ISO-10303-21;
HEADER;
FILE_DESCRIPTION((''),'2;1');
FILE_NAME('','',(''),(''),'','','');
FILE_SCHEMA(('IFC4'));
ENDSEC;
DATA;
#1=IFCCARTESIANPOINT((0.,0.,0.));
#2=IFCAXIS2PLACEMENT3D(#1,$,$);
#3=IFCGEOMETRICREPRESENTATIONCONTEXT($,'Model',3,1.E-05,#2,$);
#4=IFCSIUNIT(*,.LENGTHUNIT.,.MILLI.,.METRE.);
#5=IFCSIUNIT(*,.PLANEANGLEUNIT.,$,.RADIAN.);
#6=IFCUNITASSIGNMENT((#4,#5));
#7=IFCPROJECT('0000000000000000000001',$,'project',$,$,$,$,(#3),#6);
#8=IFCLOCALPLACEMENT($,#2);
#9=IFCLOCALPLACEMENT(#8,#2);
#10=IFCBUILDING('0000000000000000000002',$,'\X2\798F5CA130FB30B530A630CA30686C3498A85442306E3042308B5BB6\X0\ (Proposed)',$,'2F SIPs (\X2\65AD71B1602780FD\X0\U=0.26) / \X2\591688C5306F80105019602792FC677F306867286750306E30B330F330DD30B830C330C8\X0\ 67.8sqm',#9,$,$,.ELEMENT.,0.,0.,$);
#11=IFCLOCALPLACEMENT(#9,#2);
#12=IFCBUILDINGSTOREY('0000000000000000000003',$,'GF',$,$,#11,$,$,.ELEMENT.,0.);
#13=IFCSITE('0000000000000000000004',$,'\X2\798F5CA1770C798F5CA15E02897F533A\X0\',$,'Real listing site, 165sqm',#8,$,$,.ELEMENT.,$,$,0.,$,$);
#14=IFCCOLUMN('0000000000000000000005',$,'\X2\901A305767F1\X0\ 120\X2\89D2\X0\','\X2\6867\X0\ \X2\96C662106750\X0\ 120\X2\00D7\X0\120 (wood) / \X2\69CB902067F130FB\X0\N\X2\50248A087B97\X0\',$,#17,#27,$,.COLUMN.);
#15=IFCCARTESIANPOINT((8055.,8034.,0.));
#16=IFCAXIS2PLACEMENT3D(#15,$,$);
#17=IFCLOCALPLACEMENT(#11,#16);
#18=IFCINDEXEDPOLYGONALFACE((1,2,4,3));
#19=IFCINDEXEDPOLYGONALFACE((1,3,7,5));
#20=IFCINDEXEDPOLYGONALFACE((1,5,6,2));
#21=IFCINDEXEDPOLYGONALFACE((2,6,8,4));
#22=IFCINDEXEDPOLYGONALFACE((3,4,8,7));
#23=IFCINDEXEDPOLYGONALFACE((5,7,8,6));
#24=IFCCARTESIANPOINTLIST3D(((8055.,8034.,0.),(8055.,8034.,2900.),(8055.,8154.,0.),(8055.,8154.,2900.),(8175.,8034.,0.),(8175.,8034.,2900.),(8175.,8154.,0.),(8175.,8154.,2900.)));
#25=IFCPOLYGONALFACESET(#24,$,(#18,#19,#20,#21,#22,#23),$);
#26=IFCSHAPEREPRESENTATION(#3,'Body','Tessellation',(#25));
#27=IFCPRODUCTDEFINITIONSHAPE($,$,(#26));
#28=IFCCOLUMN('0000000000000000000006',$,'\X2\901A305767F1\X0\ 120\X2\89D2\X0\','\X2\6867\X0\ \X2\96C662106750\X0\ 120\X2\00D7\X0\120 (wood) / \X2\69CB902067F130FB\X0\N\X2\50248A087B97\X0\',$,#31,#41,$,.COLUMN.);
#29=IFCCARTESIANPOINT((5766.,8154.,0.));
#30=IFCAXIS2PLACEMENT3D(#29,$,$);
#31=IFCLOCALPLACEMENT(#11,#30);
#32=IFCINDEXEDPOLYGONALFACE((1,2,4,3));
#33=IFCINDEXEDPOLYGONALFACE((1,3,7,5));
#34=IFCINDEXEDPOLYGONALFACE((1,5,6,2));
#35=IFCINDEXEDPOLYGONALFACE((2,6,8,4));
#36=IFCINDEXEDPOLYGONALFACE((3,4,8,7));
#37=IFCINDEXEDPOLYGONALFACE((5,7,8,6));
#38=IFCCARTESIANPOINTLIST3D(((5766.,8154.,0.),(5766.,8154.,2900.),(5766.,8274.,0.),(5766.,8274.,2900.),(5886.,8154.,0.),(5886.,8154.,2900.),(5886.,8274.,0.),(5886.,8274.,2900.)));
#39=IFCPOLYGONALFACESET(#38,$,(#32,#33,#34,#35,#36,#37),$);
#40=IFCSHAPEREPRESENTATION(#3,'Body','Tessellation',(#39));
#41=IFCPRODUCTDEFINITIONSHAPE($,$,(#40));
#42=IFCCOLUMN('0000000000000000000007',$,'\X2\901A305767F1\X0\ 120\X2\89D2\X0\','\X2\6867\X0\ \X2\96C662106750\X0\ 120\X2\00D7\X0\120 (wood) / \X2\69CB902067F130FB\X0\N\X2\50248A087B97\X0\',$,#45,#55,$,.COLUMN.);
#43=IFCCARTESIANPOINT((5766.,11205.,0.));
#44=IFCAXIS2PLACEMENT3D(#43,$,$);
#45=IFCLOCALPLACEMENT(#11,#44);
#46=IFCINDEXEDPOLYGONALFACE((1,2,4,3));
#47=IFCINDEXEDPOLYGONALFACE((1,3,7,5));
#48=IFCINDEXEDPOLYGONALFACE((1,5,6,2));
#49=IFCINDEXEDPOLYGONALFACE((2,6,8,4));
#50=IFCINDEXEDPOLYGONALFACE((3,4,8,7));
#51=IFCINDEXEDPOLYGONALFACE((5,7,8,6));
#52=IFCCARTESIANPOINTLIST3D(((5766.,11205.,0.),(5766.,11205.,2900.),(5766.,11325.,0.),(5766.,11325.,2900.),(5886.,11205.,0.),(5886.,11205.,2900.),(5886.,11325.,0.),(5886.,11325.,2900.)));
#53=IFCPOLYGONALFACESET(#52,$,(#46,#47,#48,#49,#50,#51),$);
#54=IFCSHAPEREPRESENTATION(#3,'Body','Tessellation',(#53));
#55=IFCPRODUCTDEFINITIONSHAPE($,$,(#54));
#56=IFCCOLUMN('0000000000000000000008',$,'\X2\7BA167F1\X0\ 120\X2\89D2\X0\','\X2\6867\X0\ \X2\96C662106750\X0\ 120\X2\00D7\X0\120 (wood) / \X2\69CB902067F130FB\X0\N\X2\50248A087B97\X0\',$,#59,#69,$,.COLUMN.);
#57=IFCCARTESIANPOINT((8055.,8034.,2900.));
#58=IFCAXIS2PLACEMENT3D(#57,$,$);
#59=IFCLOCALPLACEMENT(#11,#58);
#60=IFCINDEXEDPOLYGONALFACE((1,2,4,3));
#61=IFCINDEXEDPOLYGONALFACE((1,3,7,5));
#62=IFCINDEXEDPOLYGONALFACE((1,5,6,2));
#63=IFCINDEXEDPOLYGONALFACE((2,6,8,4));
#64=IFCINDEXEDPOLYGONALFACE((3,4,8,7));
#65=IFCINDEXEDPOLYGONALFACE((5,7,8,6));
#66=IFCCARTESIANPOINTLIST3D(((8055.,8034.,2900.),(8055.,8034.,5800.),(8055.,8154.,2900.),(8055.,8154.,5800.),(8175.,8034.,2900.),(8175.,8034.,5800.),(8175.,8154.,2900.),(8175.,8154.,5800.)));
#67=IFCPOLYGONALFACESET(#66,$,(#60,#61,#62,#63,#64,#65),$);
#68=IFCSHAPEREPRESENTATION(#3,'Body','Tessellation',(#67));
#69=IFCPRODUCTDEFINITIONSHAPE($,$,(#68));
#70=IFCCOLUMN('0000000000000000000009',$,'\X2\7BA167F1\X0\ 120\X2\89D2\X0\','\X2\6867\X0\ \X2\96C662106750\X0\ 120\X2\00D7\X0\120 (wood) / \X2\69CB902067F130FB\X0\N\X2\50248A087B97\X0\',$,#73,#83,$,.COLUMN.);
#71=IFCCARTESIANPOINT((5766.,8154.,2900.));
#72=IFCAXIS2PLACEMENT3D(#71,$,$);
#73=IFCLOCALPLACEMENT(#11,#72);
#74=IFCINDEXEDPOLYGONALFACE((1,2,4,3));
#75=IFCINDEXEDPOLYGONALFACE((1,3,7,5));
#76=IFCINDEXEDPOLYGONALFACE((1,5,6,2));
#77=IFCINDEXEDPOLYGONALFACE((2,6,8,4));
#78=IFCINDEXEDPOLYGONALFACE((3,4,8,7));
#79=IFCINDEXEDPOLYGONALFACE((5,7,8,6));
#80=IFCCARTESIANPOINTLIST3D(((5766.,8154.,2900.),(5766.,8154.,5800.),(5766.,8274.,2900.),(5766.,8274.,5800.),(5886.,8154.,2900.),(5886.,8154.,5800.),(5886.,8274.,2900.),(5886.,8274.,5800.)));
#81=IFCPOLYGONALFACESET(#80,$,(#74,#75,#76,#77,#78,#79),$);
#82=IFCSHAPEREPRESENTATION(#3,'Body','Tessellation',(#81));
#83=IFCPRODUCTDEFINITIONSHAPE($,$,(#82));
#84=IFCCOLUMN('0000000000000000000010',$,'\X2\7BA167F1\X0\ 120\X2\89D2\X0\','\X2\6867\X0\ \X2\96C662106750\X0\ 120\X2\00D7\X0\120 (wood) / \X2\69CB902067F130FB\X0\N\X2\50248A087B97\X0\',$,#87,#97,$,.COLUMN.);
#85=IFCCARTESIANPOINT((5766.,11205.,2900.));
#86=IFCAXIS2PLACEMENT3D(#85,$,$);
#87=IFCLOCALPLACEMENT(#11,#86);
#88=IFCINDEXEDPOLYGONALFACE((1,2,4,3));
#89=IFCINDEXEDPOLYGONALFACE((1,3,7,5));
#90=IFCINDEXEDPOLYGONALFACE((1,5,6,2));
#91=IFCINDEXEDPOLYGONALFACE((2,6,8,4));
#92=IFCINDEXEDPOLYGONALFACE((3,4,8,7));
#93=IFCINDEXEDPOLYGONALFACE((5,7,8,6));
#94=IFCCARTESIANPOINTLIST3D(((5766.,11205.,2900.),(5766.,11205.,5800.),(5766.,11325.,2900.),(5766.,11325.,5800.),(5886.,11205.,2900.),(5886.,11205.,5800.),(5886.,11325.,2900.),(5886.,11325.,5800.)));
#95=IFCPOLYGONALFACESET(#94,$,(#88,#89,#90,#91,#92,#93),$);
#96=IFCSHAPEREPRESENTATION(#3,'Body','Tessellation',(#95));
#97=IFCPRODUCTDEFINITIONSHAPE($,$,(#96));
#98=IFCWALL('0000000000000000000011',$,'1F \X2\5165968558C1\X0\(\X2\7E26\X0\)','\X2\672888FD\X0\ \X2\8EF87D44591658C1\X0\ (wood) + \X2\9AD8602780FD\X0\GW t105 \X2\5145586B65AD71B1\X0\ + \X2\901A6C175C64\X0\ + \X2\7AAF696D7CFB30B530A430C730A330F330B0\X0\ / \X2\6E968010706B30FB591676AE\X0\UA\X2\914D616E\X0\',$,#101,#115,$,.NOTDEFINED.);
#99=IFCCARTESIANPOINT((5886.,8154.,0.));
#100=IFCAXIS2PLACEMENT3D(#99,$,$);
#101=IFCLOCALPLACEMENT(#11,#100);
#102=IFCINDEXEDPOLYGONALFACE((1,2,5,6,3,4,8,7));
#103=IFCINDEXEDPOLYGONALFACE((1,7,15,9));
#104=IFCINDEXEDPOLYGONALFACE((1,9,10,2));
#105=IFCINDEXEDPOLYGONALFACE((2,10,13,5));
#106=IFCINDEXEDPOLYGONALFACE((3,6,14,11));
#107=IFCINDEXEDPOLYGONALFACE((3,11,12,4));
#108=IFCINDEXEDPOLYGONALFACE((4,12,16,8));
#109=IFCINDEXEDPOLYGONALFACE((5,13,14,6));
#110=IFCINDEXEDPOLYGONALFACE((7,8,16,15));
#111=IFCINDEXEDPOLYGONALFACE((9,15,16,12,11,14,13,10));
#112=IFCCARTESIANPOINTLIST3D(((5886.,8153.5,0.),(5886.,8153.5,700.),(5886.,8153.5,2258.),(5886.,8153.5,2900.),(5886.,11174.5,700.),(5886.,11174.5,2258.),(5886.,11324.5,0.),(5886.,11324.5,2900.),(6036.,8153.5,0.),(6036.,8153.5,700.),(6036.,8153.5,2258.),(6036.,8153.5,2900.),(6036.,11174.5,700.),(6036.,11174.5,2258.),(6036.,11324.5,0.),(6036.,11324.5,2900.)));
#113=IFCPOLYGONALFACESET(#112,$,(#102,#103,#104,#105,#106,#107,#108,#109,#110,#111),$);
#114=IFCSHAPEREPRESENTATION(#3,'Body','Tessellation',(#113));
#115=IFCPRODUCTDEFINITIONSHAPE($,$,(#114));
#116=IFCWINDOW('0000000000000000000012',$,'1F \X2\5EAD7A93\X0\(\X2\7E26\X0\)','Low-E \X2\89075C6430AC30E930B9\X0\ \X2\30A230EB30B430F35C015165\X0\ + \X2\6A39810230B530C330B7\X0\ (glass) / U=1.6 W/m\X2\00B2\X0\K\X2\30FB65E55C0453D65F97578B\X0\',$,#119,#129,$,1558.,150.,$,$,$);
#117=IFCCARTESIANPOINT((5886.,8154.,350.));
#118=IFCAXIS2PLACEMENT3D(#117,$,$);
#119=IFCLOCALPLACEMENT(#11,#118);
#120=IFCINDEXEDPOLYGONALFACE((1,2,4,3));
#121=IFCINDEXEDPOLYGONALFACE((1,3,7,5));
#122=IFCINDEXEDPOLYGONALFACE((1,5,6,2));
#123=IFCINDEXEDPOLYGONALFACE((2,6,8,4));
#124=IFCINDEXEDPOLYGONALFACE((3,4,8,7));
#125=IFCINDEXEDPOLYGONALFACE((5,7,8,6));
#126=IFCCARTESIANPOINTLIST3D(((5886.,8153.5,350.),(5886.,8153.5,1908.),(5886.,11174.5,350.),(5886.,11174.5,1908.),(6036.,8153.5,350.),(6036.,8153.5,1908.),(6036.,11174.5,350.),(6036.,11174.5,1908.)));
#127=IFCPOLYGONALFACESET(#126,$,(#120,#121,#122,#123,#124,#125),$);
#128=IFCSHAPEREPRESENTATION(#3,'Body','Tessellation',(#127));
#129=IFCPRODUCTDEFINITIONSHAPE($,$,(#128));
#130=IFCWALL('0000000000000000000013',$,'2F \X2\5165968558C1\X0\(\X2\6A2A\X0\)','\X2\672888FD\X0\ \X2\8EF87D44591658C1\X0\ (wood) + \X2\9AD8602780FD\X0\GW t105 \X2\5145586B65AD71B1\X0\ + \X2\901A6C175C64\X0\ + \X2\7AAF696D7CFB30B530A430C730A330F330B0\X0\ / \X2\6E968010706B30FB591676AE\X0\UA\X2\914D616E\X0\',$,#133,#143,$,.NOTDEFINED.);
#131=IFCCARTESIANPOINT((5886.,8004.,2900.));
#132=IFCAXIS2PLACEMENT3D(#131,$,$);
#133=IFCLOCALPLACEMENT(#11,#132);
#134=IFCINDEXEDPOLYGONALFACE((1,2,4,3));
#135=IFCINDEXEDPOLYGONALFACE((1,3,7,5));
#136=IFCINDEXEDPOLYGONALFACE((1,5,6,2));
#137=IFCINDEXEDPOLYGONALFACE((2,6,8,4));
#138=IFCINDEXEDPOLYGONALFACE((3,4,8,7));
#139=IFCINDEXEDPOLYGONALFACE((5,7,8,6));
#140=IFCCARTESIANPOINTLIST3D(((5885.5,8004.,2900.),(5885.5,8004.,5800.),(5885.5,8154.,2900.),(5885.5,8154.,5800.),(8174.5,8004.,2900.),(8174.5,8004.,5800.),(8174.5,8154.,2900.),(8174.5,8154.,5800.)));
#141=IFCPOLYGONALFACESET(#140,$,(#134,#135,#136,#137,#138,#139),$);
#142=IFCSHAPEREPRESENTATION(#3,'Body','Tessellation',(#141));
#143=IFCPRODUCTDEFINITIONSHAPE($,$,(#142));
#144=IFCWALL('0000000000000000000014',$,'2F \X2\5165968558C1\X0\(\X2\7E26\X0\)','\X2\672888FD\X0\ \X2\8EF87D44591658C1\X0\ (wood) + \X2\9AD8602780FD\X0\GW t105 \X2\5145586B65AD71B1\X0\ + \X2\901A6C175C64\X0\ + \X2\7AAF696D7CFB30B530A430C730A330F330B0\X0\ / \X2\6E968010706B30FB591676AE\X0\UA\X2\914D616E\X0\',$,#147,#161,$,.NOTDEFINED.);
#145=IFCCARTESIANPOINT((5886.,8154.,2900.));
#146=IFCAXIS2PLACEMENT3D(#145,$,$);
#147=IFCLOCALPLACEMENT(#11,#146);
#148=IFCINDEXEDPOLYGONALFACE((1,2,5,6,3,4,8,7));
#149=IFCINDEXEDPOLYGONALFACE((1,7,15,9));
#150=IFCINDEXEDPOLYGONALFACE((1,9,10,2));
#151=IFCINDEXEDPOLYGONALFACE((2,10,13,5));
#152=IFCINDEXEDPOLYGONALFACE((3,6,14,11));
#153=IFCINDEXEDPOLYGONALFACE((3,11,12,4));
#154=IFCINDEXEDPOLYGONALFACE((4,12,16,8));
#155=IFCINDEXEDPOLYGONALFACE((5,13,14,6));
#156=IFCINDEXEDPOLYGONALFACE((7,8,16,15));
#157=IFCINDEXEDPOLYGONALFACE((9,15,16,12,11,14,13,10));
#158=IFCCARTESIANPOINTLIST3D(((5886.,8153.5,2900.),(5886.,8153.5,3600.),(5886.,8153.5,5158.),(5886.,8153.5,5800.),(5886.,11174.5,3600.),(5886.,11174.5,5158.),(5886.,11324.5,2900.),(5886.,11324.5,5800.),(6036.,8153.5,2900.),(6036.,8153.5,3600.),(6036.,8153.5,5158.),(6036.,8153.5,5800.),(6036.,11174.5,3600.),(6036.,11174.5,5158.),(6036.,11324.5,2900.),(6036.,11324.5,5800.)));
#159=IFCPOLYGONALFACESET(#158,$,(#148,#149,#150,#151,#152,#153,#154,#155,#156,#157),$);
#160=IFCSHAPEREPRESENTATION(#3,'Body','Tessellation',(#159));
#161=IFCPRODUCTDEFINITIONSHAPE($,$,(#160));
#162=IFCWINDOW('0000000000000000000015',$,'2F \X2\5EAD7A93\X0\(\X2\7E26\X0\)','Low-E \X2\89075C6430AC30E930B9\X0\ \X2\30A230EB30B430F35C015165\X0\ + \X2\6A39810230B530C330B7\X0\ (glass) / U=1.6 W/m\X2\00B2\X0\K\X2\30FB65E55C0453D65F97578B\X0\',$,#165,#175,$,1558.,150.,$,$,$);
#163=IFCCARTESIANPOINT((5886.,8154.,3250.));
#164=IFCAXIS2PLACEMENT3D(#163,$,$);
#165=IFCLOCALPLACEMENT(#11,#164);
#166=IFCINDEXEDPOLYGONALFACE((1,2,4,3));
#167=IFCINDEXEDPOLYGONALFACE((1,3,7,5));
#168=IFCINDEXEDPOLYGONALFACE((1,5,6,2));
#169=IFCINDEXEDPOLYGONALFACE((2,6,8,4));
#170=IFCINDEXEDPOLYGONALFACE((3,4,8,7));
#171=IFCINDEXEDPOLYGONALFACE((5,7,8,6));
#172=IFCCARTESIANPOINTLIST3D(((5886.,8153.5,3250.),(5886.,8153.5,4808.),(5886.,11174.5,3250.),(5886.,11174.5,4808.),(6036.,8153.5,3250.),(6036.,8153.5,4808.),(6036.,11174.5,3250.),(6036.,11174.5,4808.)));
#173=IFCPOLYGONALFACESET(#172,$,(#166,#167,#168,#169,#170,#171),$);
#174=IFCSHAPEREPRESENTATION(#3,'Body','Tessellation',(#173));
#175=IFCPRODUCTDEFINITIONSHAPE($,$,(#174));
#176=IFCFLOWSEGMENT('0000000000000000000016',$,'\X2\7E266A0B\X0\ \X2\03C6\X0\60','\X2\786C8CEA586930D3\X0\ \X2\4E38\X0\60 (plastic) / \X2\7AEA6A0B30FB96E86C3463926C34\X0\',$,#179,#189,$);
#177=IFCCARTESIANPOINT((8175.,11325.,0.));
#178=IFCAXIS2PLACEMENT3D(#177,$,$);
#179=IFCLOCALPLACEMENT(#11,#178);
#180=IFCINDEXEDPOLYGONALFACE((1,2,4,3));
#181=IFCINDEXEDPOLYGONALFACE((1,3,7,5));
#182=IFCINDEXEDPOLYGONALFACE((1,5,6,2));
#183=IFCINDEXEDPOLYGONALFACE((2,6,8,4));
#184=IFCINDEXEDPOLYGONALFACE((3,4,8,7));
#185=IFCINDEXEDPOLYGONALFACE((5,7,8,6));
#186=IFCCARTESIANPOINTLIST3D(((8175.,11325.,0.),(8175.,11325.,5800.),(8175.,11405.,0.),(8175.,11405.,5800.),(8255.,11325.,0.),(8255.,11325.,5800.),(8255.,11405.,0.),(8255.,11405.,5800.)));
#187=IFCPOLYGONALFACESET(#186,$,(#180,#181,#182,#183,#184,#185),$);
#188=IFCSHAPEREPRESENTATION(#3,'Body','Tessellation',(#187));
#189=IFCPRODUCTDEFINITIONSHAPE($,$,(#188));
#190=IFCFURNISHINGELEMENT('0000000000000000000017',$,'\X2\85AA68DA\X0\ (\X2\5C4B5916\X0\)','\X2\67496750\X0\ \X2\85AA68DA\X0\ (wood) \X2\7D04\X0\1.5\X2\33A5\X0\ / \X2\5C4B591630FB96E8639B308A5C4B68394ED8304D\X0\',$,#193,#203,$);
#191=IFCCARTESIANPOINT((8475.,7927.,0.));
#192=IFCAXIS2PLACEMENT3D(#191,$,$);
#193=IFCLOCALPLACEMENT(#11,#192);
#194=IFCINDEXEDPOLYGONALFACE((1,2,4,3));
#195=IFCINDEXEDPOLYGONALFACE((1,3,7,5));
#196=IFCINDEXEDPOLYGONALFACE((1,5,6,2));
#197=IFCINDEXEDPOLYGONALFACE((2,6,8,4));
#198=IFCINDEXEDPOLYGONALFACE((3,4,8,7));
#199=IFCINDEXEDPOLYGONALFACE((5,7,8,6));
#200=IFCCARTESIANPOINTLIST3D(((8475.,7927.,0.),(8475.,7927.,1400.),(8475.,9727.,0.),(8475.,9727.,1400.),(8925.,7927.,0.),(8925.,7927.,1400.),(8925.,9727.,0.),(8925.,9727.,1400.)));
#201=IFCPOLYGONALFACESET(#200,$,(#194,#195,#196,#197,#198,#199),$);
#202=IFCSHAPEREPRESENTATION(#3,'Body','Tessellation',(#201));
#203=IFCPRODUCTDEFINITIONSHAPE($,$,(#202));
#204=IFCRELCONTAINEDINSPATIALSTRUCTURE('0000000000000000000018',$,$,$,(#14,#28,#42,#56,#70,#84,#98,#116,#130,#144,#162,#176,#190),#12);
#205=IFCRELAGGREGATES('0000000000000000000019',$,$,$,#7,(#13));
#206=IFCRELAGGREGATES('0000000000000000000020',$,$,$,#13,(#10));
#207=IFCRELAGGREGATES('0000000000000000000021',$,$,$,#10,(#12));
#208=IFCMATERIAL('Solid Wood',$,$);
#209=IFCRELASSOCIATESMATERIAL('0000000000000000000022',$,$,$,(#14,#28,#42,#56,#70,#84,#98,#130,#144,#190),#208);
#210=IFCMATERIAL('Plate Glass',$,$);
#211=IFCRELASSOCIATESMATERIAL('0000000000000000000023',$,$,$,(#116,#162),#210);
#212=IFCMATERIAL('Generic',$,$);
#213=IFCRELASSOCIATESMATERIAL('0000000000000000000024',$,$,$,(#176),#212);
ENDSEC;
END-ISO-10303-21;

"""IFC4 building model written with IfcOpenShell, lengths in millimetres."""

from ifc_helpers import new_model, si_unit, frame, frame_2d, origin, place, context, project, spatial, rectangle, extrude, material, element, fill, save


model = new_model("IFC4")

# Units and contexts
model_context = context("Model", 3, precision=1e-05, world=origin())
ifc_project = project(units=[si_unit("LENGTHUNIT", "METRE", prefix="MILLI"), si_unit("PLANEANGLEUNIT", "RADIAN")], contexts=[model_context])

# Site, building, storey
site_placement = place(None, origin())
site = spatial("IfcSite", under=ifc_project, at=site_placement, Name="福岡県福岡市西区", ObjectType="Real listing site, 165sqm", CompositionType="ELEMENT", RefElevation=0.0)
building_placement = place(site_placement, origin())
building = spatial("IfcBuilding", under=site, at=building_placement, Name="福岡・サウナと水風呂のある家 (Proposed)", ObjectType="2F SIPs (断熱性能U=0.26) / 外装は耐候性鋼板と木材のコンポジット 67.8sqm", CompositionType="ELEMENT", ElevationOfRefHeight=0.0, ElevationOfTerrain=0.0)
storey_placement = place(building_placement, origin())
storey = spatial("IfcBuildingStorey", under=building, at=storey_placement, Name="GF", CompositionType="ELEMENT", Elevation=0.0)

# Columns
ifc_material_1 = material(Name="Solid Wood")
column_1_placement = place(storey_placement, frame((8055.0, 8034.0, 0.0)))
element("IfcColumn", 1, at=column_1_placement, inside=storey, material=ifc_material_1, Name="通し柱 120角", Description="桧 集成材 120×120 (wood) / 構造柱・N値計算", PredefinedType="COLUMN", context=model_context, shape_type="SweptSolid", body=[
    extrude(rectangle(XDim=120.0, YDim=120.0, at=frame_2d((60.0, 60.0))), frame((8055.0, 8034.0, 0.0)), (0.0, 0.0, 1.0), 2900.0),
])
column_2_placement = place(storey_placement, frame((5766.0, 8154.0, 0.0)))
element("IfcColumn", 2, at=column_2_placement, inside=storey, material=ifc_material_1, Name="通し柱 120角", Description="桧 集成材 120×120 (wood) / 構造柱・N値計算", PredefinedType="COLUMN", context=model_context, shape_type="SweptSolid", body=[
    extrude(rectangle(XDim=120.0, YDim=120.0, at=frame_2d((60.0, 60.0))), frame((5766.0, 8154.0, 0.0)), (0.0, 0.0, 1.0), 2900.0),
])
column_3_placement = place(storey_placement, frame((5766.0, 11205.0, 0.0)))
element("IfcColumn", 3, at=column_3_placement, inside=storey, material=ifc_material_1, Name="通し柱 120角", Description="桧 集成材 120×120 (wood) / 構造柱・N値計算", PredefinedType="COLUMN", context=model_context, shape_type="SweptSolid", body=[
    extrude(rectangle(XDim=120.0, YDim=120.0, at=frame_2d((60.0, 60.0))), frame((5766.0, 11205.0, 0.0)), (0.0, 0.0, 1.0), 2900.0),
])
column_4_placement = place(storey_placement, frame((8055.0, 8034.0, 2900.0)))
element("IfcColumn", 4, at=column_4_placement, inside=storey, material=ifc_material_1, Name="管柱 120角", Description="桧 集成材 120×120 (wood) / 構造柱・N値計算", PredefinedType="COLUMN", context=model_context, shape_type="SweptSolid", body=[
    extrude(rectangle(XDim=120.0, YDim=120.0, at=frame_2d((60.0, 60.0))), frame((8055.0, 8034.0, 2900.0)), (0.0, 0.0, 1.0), 2900.0),
])
column_5_placement = place(storey_placement, frame((5766.0, 8154.0, 2900.0)))
element("IfcColumn", 5, at=column_5_placement, inside=storey, material=ifc_material_1, Name="管柱 120角", Description="桧 集成材 120×120 (wood) / 構造柱・N値計算", PredefinedType="COLUMN", context=model_context, shape_type="SweptSolid", body=[
    extrude(rectangle(XDim=120.0, YDim=120.0, at=frame_2d((60.0, 60.0))), frame((5766.0, 8154.0, 2900.0)), (0.0, 0.0, 1.0), 2900.0),
])
column_6_placement = place(storey_placement, frame((5766.0, 11205.0, 2900.0)))
element("IfcColumn", 6, at=column_6_placement, inside=storey, material=ifc_material_1, Name="管柱 120角", Description="桧 集成材 120×120 (wood) / 構造柱・N値計算", PredefinedType="COLUMN", context=model_context, shape_type="SweptSolid", body=[
    extrude(rectangle(XDim=120.0, YDim=120.0, at=frame_2d((60.0, 60.0))), frame((5766.0, 11205.0, 2900.0)), (0.0, 0.0, 1.0), 2900.0),
])

# Wall, opening, window
wall_1_placement = place(storey_placement, frame((5886.0, 8154.0, 0.0)))
wall_1 = element("IfcWall", 7, at=wall_1_placement, inside=storey, material=ifc_material_1, Name="1F 入隅壁(縦)", Description="木製 軸組外壁 (wood) + 高性能GW t105 充填断熱 + 通気層 + 窯業系サイディング / 準耐火・外皮UA配慮", PredefinedType="NOTDEFINED", context=model_context, shape_type="SweptSolid", body=[
    extrude(rectangle(XDim=150.0, YDim=3171.0, at=frame_2d((75.0, 1585.0))), frame((5886.0, 8154.0, 0.0)), (0.0, 0.0, 1.0), 2900.0),
])
opening_1_placement = place(storey_placement, frame((5886.0, 8154.0, 350.0)))
opening_1 = element("IfcOpeningElement", 8, at=opening_1_placement, cuts=wall_1, PredefinedType="NOTDEFINED", context=model_context, shape_type="SweptSolid", body=[
    extrude(rectangle(XDim=150.0, YDim=3021.0, at=frame_2d((75.0, 1510.0))), frame((5886.0, 8154.0, 350.0)), (0.0, 0.0, 1.0), 1558.0),
])
ifc_material_2 = material(Name="Plate Glass")
window_1_placement = place(storey_placement, frame((5886.0, 8154.0, 350.0)))
window_1 = element("IfcWindow", 9, at=window_1_placement, inside=storey, material=ifc_material_2, Name="1F 庭窓(縦)", Description="Low-E 複層ガラス アルゴン封入 + 樹脂サッシ (glass) / U=1.6 W/m²K・日射取得型", OverallHeight=1558.0, OverallWidth=150.0, context=model_context, shape_type="SweptSolid", body=[
    extrude(rectangle(XDim=150.0, YDim=3021.0, at=frame_2d((75.0, 1510.0))), frame((5886.0, 8154.0, 350.0)), (0.0, 0.0, 1.0), 1558.0),
])
fill(opening_1, window_1)

# Wall
wall_2_placement = place(storey_placement, frame((5886.0, 8004.0, 2900.0)))
element("IfcWall", 10, at=wall_2_placement, inside=storey, material=ifc_material_1, Name="2F 入隅壁(横)", Description="木製 軸組外壁 (wood) + 高性能GW t105 充填断熱 + 通気層 + 窯業系サイディング / 準耐火・外皮UA配慮", PredefinedType="NOTDEFINED", context=model_context, shape_type="SweptSolid", body=[
    extrude(rectangle(XDim=2289.0, YDim=150.0, at=frame_2d((1144.0, 75.0))), frame((5886.0, 8004.0, 2900.0)), (0.0, 0.0, 1.0), 2900.0),
])

# Wall, opening, window
wall_3_placement = place(storey_placement, frame((5886.0, 8154.0, 2900.0)))
wall_3 = element("IfcWall", 11, at=wall_3_placement, inside=storey, material=ifc_material_1, Name="2F 入隅壁(縦)", Description="木製 軸組外壁 (wood) + 高性能GW t105 充填断熱 + 通気層 + 窯業系サイディング / 準耐火・外皮UA配慮", PredefinedType="NOTDEFINED", context=model_context, shape_type="SweptSolid", body=[
    extrude(rectangle(XDim=150.0, YDim=3171.0, at=frame_2d((75.0, 1585.0))), frame((5886.0, 8154.0, 2900.0)), (0.0, 0.0, 1.0), 2900.0),
])
opening_2_placement = place(storey_placement, frame((5886.0, 8154.0, 3250.0)))
opening_2 = element("IfcOpeningElement", 12, at=opening_2_placement, cuts=wall_3, PredefinedType="NOTDEFINED", context=model_context, shape_type="SweptSolid", body=[
    extrude(rectangle(XDim=150.0, YDim=3021.0, at=frame_2d((75.0, 1510.0))), frame((5886.0, 8154.0, 3250.0)), (0.0, 0.0, 1.0), 1558.0),
])
window_2_placement = place(storey_placement, frame((5886.0, 8154.0, 3250.0)))
window_2 = element("IfcWindow", 13, at=window_2_placement, inside=storey, material=ifc_material_2, Name="2F 庭窓(縦)", Description="Low-E 複層ガラス アルゴン封入 + 樹脂サッシ (glass) / U=1.6 W/m²K・日射取得型", OverallHeight=1558.0, OverallWidth=150.0, context=model_context, shape_type="SweptSolid", body=[
    extrude(rectangle(XDim=150.0, YDim=3021.0, at=frame_2d((75.0, 1510.0))), frame((5886.0, 8154.0, 3250.0)), (0.0, 0.0, 1.0), 1558.0),
])
fill(opening_2, window_2)

# Flow segment
ifc_material_3 = material(Name="Generic")
flow_segment_placement = place(storey_placement, frame((8175.0, 11325.0, 0.0)))
element("IfcFlowSegment", 14, at=flow_segment_placement, inside=storey, material=ifc_material_3, Name="縦樋 φ60", Description="硬質塩ビ 丸60 (plastic) / 竪樋・雨水排水", context=model_context, shape_type="SweptSolid", body=[
    extrude(rectangle(XDim=80.0, YDim=80.0, at=frame_2d((40.0, 40.0))), frame((8175.0, 11325.0, 0.0)), (0.0, 0.0, 1.0), 5800.0),
])

# Furnishing element
furnishing_placement = place(storey_placement, frame((8475.0, 7927.0, 0.0)))
element("IfcFurnishingElement", 15, at=furnishing_placement, inside=storey, material=ifc_material_1, Name="薪棚 (屋外)", Description="杉材 薪棚 (wood) 約1.5㎥ / 屋外・雨掛り屋根付き", context=model_context, shape_type="SweptSolid", body=[
    extrude(rectangle(XDim=450.0, YDim=1800.0, at=frame_2d((225.0, 900.0))), frame((8475.0, 7927.0, 0.0)), (0.0, 0.0, 1.0), 1400.0),
])

save(model, "model.ifc")
